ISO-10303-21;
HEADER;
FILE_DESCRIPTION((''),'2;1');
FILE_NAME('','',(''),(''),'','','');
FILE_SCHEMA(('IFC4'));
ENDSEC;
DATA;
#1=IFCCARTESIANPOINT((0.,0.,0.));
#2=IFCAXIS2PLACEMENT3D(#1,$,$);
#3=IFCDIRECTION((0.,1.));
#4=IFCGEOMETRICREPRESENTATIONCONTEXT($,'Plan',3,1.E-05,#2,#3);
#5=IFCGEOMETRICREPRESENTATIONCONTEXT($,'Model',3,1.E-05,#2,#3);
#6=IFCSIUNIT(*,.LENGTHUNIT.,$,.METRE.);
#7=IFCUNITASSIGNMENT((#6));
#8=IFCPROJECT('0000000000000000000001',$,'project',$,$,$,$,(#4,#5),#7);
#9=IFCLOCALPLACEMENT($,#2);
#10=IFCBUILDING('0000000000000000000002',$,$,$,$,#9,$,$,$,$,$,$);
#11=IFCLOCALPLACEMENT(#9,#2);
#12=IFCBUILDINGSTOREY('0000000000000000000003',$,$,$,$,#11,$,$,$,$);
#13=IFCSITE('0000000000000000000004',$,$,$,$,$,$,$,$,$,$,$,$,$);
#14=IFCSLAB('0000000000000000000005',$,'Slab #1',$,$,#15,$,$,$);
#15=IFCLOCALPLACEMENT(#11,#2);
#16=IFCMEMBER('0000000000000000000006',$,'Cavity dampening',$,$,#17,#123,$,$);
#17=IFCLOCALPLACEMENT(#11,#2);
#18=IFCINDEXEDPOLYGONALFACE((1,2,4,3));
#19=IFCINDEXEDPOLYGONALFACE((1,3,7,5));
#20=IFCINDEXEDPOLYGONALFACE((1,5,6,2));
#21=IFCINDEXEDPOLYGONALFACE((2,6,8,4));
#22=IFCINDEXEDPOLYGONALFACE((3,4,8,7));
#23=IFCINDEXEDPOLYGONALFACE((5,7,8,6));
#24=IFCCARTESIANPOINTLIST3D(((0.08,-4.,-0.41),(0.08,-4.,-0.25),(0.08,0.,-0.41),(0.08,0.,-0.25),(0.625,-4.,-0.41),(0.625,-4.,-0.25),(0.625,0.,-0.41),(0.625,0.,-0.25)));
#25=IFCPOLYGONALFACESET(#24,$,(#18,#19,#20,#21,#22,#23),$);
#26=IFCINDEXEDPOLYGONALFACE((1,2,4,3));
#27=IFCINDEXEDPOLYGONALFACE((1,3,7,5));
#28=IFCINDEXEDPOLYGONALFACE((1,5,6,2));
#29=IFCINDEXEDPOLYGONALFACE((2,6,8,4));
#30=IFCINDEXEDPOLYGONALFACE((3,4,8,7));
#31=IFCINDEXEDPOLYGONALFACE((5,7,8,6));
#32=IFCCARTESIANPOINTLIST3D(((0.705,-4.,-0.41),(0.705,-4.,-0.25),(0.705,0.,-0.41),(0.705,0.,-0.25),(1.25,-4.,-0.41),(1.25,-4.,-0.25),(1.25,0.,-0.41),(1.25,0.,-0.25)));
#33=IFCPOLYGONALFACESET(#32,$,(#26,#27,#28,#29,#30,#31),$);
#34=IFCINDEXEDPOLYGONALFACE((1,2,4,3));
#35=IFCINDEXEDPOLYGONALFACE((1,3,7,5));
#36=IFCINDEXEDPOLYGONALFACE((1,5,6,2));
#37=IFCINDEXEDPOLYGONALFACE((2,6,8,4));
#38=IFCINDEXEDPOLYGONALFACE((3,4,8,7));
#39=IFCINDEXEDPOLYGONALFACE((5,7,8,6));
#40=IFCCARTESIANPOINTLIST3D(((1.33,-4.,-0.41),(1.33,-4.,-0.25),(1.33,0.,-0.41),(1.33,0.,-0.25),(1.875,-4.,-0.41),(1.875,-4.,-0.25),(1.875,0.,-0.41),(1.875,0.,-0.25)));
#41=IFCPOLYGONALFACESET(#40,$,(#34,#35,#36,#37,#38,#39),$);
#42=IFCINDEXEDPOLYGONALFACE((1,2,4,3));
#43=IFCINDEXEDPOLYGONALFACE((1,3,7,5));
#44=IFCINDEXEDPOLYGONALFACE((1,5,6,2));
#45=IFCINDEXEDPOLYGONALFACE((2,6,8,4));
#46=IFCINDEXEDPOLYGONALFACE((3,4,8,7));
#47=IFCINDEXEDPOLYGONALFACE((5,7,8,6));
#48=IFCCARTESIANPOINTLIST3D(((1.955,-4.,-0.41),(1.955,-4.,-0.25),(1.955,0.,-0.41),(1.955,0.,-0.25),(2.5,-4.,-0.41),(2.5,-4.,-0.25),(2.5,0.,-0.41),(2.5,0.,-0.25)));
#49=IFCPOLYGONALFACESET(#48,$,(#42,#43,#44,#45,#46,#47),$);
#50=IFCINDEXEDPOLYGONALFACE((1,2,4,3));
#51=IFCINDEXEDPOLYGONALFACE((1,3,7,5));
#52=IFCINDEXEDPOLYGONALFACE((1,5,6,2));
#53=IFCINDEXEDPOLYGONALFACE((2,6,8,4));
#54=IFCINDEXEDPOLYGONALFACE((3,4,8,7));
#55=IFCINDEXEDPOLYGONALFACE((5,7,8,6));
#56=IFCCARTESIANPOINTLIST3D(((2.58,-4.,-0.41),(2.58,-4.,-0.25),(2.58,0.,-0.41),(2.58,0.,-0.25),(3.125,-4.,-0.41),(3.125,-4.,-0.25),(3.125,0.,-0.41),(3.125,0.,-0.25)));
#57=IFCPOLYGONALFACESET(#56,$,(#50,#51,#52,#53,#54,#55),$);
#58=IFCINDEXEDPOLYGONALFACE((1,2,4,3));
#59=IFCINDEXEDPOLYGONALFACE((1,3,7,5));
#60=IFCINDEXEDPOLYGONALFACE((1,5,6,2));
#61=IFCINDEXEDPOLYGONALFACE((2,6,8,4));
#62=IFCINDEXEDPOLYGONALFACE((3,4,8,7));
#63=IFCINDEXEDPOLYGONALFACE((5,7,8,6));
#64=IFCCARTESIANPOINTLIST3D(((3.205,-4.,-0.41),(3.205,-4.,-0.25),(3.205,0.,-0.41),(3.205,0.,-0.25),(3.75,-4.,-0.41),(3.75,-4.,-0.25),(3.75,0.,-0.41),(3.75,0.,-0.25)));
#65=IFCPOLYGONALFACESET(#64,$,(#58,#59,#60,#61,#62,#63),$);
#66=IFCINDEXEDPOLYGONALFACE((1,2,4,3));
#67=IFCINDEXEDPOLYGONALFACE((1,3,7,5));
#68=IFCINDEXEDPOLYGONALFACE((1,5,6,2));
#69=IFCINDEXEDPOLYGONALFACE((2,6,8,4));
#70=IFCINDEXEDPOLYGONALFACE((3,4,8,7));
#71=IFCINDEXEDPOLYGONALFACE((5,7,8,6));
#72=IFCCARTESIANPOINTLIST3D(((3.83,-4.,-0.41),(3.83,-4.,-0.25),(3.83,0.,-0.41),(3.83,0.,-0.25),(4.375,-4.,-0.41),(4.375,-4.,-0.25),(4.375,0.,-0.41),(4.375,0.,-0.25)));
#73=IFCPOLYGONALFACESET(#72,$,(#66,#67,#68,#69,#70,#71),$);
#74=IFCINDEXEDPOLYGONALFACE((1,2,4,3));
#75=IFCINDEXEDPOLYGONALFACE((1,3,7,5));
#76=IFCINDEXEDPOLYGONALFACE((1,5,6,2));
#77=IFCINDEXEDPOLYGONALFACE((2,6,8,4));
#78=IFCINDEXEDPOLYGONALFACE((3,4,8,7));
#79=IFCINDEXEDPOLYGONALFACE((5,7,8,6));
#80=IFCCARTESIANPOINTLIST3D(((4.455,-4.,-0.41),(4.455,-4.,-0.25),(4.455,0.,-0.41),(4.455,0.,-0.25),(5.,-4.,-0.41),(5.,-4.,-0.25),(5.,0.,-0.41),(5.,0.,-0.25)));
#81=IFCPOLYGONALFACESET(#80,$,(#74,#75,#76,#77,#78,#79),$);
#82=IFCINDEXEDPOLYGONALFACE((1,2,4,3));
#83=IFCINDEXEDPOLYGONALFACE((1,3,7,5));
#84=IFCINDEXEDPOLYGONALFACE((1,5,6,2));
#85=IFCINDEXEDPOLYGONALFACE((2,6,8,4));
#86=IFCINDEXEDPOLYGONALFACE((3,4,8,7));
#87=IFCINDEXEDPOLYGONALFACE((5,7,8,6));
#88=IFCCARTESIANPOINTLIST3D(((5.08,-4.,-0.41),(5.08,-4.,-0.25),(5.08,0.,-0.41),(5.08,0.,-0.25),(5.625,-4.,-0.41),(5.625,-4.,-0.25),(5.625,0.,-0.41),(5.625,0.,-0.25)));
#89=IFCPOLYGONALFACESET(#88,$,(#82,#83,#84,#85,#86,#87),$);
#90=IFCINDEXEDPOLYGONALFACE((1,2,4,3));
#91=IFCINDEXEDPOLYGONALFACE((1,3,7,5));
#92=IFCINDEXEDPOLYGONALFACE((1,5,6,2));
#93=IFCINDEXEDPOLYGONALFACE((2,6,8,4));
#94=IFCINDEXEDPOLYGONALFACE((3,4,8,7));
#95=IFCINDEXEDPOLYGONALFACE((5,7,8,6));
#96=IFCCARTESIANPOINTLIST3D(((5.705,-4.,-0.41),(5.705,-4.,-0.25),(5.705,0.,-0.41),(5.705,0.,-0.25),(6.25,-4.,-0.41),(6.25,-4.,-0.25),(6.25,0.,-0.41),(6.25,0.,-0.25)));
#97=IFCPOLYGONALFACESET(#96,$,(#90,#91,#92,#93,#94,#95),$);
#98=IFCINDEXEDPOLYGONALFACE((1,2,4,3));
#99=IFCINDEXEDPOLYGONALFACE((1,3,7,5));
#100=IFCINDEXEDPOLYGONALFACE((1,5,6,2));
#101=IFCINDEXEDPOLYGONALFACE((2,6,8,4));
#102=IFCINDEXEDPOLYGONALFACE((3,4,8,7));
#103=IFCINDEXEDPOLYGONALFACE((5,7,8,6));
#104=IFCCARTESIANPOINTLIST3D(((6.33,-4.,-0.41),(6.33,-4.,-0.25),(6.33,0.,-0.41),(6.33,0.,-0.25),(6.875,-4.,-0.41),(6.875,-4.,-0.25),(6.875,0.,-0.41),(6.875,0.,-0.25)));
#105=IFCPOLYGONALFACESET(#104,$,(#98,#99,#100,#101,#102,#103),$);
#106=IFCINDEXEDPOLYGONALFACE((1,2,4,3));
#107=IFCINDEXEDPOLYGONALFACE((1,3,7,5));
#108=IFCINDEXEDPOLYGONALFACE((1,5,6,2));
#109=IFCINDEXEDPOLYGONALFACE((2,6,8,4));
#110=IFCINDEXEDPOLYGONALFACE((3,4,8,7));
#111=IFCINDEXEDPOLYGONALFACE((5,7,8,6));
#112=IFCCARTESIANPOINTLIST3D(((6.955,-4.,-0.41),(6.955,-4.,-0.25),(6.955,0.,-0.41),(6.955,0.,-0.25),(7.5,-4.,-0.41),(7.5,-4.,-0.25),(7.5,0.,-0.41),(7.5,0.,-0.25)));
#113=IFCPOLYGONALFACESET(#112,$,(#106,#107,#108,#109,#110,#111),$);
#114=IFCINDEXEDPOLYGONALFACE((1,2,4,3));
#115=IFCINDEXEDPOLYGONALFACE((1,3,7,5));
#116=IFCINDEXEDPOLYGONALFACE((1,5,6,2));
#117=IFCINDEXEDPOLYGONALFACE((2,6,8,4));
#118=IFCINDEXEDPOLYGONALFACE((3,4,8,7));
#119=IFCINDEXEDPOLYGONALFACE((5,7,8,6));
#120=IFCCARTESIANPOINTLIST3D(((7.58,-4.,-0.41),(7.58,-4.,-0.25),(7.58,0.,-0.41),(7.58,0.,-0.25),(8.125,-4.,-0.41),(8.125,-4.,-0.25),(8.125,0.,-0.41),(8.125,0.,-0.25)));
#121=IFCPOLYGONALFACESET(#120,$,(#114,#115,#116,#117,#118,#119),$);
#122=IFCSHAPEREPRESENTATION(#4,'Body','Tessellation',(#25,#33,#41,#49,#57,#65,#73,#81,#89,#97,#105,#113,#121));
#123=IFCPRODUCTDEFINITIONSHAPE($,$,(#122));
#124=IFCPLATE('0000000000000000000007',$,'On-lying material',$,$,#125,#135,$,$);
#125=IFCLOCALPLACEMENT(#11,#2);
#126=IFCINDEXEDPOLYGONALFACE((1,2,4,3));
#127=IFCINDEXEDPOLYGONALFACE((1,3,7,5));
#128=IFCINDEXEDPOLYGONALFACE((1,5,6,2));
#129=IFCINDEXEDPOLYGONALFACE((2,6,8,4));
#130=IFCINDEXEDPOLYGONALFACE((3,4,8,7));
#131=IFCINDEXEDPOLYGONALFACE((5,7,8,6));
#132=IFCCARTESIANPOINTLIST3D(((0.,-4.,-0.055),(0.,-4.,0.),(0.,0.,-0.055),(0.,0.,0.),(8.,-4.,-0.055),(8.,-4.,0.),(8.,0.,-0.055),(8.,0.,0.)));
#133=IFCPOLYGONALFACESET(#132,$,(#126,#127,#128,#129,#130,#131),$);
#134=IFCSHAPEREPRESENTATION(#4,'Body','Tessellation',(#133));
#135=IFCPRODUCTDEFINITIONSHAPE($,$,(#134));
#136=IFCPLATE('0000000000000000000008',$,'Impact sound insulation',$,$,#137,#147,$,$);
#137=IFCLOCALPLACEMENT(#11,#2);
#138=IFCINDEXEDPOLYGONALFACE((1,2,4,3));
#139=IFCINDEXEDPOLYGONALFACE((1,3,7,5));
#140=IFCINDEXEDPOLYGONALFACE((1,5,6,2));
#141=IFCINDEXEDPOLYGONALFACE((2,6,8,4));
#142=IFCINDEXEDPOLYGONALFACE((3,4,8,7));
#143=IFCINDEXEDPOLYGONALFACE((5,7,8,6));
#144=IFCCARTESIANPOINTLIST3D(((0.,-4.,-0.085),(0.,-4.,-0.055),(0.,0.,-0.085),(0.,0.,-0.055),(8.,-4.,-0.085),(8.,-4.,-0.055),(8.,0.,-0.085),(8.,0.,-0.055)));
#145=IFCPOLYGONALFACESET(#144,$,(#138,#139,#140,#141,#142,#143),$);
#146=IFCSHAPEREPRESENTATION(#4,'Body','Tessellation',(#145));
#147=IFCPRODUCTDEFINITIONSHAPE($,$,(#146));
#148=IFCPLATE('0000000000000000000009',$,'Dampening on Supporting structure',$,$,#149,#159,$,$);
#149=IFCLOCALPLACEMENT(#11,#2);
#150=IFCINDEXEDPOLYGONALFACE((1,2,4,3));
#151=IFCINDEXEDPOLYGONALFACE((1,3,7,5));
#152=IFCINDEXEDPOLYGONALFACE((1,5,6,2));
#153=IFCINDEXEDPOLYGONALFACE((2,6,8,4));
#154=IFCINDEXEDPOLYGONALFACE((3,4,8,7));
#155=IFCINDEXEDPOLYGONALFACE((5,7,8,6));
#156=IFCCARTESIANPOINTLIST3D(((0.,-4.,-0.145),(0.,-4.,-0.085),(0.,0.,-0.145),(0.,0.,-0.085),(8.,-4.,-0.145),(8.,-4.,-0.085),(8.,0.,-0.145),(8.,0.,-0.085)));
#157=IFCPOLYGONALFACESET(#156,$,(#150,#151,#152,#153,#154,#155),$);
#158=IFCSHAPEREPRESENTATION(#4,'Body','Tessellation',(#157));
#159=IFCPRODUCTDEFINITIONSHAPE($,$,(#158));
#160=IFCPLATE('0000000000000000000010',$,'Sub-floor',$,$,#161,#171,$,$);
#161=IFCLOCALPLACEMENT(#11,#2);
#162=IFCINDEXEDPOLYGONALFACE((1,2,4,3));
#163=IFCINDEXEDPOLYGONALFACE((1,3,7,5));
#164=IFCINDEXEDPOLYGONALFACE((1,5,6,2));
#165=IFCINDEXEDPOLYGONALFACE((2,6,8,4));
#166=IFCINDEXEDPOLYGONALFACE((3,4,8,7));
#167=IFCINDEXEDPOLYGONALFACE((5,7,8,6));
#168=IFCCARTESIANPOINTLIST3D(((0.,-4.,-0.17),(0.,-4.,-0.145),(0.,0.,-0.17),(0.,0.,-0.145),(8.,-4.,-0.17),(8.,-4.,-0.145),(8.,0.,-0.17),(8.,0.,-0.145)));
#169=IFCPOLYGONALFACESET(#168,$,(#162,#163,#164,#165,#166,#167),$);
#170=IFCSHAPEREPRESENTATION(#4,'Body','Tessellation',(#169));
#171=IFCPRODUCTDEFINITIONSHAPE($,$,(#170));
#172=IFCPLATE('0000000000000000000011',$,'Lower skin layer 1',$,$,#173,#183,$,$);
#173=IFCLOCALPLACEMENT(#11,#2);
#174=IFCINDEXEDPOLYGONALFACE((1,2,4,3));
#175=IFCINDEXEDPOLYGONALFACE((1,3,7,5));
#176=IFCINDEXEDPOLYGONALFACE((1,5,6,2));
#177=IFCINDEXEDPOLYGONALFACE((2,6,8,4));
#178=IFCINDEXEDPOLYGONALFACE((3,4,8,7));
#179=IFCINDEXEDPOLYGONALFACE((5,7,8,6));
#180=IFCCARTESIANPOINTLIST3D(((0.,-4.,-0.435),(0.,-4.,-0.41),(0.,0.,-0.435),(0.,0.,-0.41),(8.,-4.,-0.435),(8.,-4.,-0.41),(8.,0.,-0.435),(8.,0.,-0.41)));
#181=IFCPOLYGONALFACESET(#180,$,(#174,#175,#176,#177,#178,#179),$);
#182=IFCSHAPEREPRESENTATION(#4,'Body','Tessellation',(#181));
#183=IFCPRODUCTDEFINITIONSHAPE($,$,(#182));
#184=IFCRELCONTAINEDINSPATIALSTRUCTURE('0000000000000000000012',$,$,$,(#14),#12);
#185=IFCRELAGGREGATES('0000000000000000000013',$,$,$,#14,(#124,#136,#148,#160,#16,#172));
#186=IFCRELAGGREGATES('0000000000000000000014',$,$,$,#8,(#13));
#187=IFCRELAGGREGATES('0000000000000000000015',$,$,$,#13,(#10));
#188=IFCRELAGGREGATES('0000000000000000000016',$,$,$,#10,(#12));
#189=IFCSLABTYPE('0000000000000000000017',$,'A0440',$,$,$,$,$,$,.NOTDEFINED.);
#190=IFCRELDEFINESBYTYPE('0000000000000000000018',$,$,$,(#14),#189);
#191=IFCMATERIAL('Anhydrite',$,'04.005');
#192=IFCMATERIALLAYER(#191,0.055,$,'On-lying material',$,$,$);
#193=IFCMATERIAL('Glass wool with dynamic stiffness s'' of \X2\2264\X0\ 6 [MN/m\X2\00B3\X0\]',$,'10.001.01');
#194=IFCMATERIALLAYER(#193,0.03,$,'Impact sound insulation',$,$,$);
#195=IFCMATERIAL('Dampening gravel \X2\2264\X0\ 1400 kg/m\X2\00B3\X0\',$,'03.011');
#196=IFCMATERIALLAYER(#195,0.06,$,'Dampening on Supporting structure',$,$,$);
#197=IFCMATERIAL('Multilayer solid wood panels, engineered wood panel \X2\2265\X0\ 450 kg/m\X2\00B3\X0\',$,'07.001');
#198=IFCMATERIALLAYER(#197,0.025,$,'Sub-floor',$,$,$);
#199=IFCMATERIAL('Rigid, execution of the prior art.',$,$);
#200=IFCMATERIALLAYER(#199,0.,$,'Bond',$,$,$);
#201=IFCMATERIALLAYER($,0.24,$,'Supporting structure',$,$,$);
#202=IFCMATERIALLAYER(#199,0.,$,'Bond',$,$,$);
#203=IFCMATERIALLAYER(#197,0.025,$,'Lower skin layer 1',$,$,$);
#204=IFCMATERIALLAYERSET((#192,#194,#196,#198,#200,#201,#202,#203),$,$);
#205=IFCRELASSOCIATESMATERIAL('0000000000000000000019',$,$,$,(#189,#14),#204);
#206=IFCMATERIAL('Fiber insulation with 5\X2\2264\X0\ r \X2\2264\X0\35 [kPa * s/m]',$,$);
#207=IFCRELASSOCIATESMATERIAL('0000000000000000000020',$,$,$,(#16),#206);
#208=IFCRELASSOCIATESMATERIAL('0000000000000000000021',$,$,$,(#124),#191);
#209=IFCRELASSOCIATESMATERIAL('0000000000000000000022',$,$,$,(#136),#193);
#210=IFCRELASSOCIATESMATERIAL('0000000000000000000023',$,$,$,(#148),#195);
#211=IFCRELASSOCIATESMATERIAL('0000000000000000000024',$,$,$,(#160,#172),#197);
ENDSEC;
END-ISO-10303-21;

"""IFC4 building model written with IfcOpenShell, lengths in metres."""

from ifc_helpers import new_model, si_unit, direction, frame, frame_2d, origin, origin_with_axes, place, context, project, spatial, rectangle, extrude, material, layer, layer_set, type_object, element, aggregate, save


model = new_model("IFC4")

# Units and contexts
plan_context = context("Plan", 3, precision=1e-05, world=origin(), true_north=direction((0.0, 1.0)))
model_context = context("Model", 3, precision=1e-05, world=origin(), true_north=direction((0.0, 1.0)))
ifc_project = project(units=[si_unit("LENGTHUNIT", "METRE")], contexts=[plan_context, model_context])

# Site, building, storey
site = spatial("IfcSite", under=ifc_project)
building_placement = place(None, origin())
building = spatial("IfcBuilding", under=site, at=building_placement)
storey_placement = place(building_placement, origin())
storey = spatial("IfcBuildingStorey", under=building, at=storey_placement)

# Slab, member, plates
ifc_material_1 = material(Name="Anhydrite", Category="04.005")
ifc_layer_1 = layer(ifc_material_1, 0.055, Name="On-lying material")
ifc_material_2 = material(Name="Glass wool with dynamic stiffness s' of ≤ 6 [MN/m³]", Category="10.001.01")
ifc_layer_2 = layer(ifc_material_2, 0.03, Name="Impact sound insulation")
ifc_material_3 = material(Name="Dampening gravel ≤ 1400 kg/m³", Category="03.011")
ifc_layer_3 = layer(ifc_material_3, 0.06, Name="Dampening on Supporting structure")
ifc_material_4 = material(Name="Multilayer solid wood panels, engineered wood panel ≥ 450 kg/m³", Category="07.001")
ifc_layer_4 = layer(ifc_material_4, 0.025, Name="Sub-floor")
ifc_material_5 = material(Name="Rigid, execution of the prior art.")
ifc_layer_5 = layer(ifc_material_5, 0.0, Name="Bond")
ifc_layer_6 = layer(None, 0.24, Name="Supporting structure")
ifc_layer_7 = layer(ifc_material_5, 0.0, Name="Bond")
ifc_layer_8 = layer(ifc_material_4, 0.025, Name="Lower skin layer 1")
ifc_layer_set = layer_set([ifc_layer_1, ifc_layer_2, ifc_layer_3, ifc_layer_4, ifc_layer_5, ifc_layer_6, ifc_layer_7, ifc_layer_8])
slab_type = type_object("IfcSlabType", Name="A0440", PredefinedType="NOTDEFINED", material=ifc_layer_set)
slab_placement = place(None, frame((0.0, 0.0, 0.0), z_axis=(0.0, 0.0, -1.0), x_axis=(1.0, 0.0, 0.0)))
slab = element("IfcSlab", 1, at=slab_placement, inside=storey, type_object=slab_type, material=ifc_layer_set, Name="Slab #1")
ifc_material_6 = material(Name="Fiber insulation with 5≤ r ≤35 [kPa * s/m]")
member_1_placement = place(slab_placement, origin())
member_1 = element("IfcMember", 2, at=member_1_placement, material=ifc_material_6, Name="Cavity dampening", context=plan_context, shape_type="SweptSolid", body=[
    extrude(rectangle(XDim=0.545, YDim=0.16, at=frame_2d((0.2725, 0.08), x_axis=(1.0, 0.0))), frame((0.08, 4.0, 0.25), z_axis=(0.0, -1.0, 0.0), x_axis=(1.0, 0.0, 0.0)), (0.0, 0.0, 1.0), 4.0),
    extrude(rectangle(XDim=0.545, YDim=0.16, at=frame_2d((0.2725, 0.08), x_axis=(1.0, 0.0))), frame((0.705, 4.0, 0.25), z_axis=(0.0, -1.0, 0.0), x_axis=(1.0, 0.0, 0.0)), (0.0, 0.0, 1.0), 4.0),
    extrude(rectangle(XDim=0.545, YDim=0.16, at=frame_2d((0.2725, 0.08), x_axis=(1.0, 0.0))), frame((1.33, 4.0, 0.25), z_axis=(0.0, -1.0, 0.0), x_axis=(1.0, 0.0, 0.0)), (0.0, 0.0, 1.0), 4.0),
    extrude(rectangle(XDim=0.545, YDim=0.16, at=frame_2d((0.2725, 0.08), x_axis=(1.0, 0.0))), frame((1.955, 4.0, 0.25), z_axis=(0.0, -1.0, 0.0), x_axis=(1.0, 0.0, 0.0)), (0.0, 0.0, 1.0), 4.0),
    extrude(rectangle(XDim=0.545, YDim=0.16, at=frame_2d((0.2725, 0.08), x_axis=(1.0, 0.0))), frame((2.58, 4.0, 0.25), z_axis=(0.0, -1.0, 0.0), x_axis=(1.0, 0.0, 0.0)), (0.0, 0.0, 1.0), 4.0),
    extrude(rectangle(XDim=0.545, YDim=0.16, at=frame_2d((0.2725, 0.08), x_axis=(1.0, 0.0))), frame((3.205, 4.0, 0.25), z_axis=(0.0, -1.0, 0.0), x_axis=(1.0, 0.0, 0.0)), (0.0, 0.0, 1.0), 4.0),
    extrude(rectangle(XDim=0.545, YDim=0.16, at=frame_2d((0.2725, 0.08), x_axis=(1.0, 0.0))), frame((3.83, 4.0, 0.25), z_axis=(0.0, -1.0, 0.0), x_axis=(1.0, 0.0, 0.0)), (0.0, 0.0, 1.0), 4.0),
    extrude(rectangle(XDim=0.545, YDim=0.16, at=frame_2d((0.2725, 0.08), x_axis=(1.0, 0.0))), frame((4.455, 4.0, 0.25), z_axis=(0.0, -1.0, 0.0), x_axis=(1.0, 0.0, 0.0)), (0.0, 0.0, 1.0), 4.0),
    extrude(rectangle(XDim=0.545, YDim=0.16, at=frame_2d((0.2725, 0.08), x_axis=(1.0, 0.0))), frame((5.08, 4.0, 0.25), z_axis=(0.0, -1.0, 0.0), x_axis=(1.0, 0.0, 0.0)), (0.0, 0.0, 1.0), 4.0),
    extrude(rectangle(XDim=0.545, YDim=0.16, at=frame_2d((0.2725, 0.08), x_axis=(1.0, 0.0))), frame((5.705, 4.0, 0.25), z_axis=(0.0, -1.0, 0.0), x_axis=(1.0, 0.0, 0.0)), (0.0, 0.0, 1.0), 4.0),
    extrude(rectangle(XDim=0.545, YDim=0.16, at=frame_2d((0.2725, 0.08), x_axis=(1.0, 0.0))), frame((6.33, 4.0, 0.25), z_axis=(0.0, -1.0, 0.0), x_axis=(1.0, 0.0, 0.0)), (0.0, 0.0, 1.0), 4.0),
    extrude(rectangle(XDim=0.545, YDim=0.16, at=frame_2d((0.2725, 0.08), x_axis=(1.0, 0.0))), frame((6.955, 4.0, 0.25), z_axis=(0.0, -1.0, 0.0), x_axis=(1.0, 0.0, 0.0)), (0.0, 0.0, 1.0), 4.0),
    extrude(rectangle(XDim=0.545, YDim=0.16, at=frame_2d((0.2725, 0.08), x_axis=(1.0, 0.0))), frame((7.58, 4.0, 0.25), z_axis=(0.0, -1.0, 0.0), x_axis=(1.0, 0.0, 0.0)), (0.0, 0.0, 1.0), 4.0),
])
plate_1_placement = place(slab_placement, origin())
plate_1 = element("IfcPlate", 3, at=plate_1_placement, material=ifc_material_1, Name="On-lying material", context=plan_context, shape_type="SweptSolid", body=[
    extrude(rectangle(XDim=8.0, YDim=4.0, at=frame_2d((4.0, 2.0), x_axis=(1.0, 0.0))), origin_with_axes(), (0.0, 0.0, 1.0), 0.055),
])
plate_2_placement = place(slab_placement, origin())
plate_2 = element("IfcPlate", 4, at=plate_2_placement, material=ifc_material_2, Name="Impact sound insulation", context=plan_context, shape_type="SweptSolid", body=[
    extrude(rectangle(XDim=8.0, YDim=4.0, at=frame_2d((4.0, 2.0), x_axis=(1.0, 0.0))), frame((0.0, 0.0, 0.055), z_axis=(0.0, 0.0, 1.0), x_axis=(1.0, 0.0, 0.0)), (0.0, 0.0, 1.0), 0.03),
])
plate_3_placement = place(slab_placement, origin())
plate_3 = element("IfcPlate", 5, at=plate_3_placement, material=ifc_material_3, Name="Dampening on Supporting structure", context=plan_context, shape_type="SweptSolid", body=[
    extrude(rectangle(XDim=8.0, YDim=4.0, at=frame_2d((4.0, 2.0), x_axis=(1.0, 0.0))), frame((0.0, 0.0, 0.085), z_axis=(0.0, 0.0, 1.0), x_axis=(1.0, 0.0, 0.0)), (0.0, 0.0, 1.0), 0.06),
])
plate_4_placement = place(slab_placement, origin())
plate_4 = element("IfcPlate", 6, at=plate_4_placement, material=ifc_material_4, Name="Sub-floor", context=plan_context, shape_type="SweptSolid", body=[
    extrude(rectangle(XDim=8.0, YDim=4.0, at=frame_2d((4.0, 2.0), x_axis=(1.0, 0.0))), frame((0.0, 0.0, 0.145), z_axis=(0.0, 0.0, 1.0), x_axis=(1.0, 0.0, 0.0)), (0.0, 0.0, 1.0), 0.025),
])
plate_5_placement = place(slab_placement, origin())
plate_5 = element("IfcPlate", 7, at=plate_5_placement, material=ifc_material_4, Name="Lower skin layer 1", context=plan_context, shape_type="SweptSolid", body=[
    extrude(rectangle(XDim=8.0, YDim=4.0, at=frame_2d((4.0, 2.0), x_axis=(1.0, 0.0))), frame((0.0, 0.0, 0.41), z_axis=(0.0, 0.0, 1.0), x_axis=(1.0, 0.0, 0.0)), (0.0, 0.0, 1.0), 0.025),
])
aggregate(slab, [plate_1, plate_2, plate_3, plate_4, member_1, plate_5])

save(model, "model.ifc")
